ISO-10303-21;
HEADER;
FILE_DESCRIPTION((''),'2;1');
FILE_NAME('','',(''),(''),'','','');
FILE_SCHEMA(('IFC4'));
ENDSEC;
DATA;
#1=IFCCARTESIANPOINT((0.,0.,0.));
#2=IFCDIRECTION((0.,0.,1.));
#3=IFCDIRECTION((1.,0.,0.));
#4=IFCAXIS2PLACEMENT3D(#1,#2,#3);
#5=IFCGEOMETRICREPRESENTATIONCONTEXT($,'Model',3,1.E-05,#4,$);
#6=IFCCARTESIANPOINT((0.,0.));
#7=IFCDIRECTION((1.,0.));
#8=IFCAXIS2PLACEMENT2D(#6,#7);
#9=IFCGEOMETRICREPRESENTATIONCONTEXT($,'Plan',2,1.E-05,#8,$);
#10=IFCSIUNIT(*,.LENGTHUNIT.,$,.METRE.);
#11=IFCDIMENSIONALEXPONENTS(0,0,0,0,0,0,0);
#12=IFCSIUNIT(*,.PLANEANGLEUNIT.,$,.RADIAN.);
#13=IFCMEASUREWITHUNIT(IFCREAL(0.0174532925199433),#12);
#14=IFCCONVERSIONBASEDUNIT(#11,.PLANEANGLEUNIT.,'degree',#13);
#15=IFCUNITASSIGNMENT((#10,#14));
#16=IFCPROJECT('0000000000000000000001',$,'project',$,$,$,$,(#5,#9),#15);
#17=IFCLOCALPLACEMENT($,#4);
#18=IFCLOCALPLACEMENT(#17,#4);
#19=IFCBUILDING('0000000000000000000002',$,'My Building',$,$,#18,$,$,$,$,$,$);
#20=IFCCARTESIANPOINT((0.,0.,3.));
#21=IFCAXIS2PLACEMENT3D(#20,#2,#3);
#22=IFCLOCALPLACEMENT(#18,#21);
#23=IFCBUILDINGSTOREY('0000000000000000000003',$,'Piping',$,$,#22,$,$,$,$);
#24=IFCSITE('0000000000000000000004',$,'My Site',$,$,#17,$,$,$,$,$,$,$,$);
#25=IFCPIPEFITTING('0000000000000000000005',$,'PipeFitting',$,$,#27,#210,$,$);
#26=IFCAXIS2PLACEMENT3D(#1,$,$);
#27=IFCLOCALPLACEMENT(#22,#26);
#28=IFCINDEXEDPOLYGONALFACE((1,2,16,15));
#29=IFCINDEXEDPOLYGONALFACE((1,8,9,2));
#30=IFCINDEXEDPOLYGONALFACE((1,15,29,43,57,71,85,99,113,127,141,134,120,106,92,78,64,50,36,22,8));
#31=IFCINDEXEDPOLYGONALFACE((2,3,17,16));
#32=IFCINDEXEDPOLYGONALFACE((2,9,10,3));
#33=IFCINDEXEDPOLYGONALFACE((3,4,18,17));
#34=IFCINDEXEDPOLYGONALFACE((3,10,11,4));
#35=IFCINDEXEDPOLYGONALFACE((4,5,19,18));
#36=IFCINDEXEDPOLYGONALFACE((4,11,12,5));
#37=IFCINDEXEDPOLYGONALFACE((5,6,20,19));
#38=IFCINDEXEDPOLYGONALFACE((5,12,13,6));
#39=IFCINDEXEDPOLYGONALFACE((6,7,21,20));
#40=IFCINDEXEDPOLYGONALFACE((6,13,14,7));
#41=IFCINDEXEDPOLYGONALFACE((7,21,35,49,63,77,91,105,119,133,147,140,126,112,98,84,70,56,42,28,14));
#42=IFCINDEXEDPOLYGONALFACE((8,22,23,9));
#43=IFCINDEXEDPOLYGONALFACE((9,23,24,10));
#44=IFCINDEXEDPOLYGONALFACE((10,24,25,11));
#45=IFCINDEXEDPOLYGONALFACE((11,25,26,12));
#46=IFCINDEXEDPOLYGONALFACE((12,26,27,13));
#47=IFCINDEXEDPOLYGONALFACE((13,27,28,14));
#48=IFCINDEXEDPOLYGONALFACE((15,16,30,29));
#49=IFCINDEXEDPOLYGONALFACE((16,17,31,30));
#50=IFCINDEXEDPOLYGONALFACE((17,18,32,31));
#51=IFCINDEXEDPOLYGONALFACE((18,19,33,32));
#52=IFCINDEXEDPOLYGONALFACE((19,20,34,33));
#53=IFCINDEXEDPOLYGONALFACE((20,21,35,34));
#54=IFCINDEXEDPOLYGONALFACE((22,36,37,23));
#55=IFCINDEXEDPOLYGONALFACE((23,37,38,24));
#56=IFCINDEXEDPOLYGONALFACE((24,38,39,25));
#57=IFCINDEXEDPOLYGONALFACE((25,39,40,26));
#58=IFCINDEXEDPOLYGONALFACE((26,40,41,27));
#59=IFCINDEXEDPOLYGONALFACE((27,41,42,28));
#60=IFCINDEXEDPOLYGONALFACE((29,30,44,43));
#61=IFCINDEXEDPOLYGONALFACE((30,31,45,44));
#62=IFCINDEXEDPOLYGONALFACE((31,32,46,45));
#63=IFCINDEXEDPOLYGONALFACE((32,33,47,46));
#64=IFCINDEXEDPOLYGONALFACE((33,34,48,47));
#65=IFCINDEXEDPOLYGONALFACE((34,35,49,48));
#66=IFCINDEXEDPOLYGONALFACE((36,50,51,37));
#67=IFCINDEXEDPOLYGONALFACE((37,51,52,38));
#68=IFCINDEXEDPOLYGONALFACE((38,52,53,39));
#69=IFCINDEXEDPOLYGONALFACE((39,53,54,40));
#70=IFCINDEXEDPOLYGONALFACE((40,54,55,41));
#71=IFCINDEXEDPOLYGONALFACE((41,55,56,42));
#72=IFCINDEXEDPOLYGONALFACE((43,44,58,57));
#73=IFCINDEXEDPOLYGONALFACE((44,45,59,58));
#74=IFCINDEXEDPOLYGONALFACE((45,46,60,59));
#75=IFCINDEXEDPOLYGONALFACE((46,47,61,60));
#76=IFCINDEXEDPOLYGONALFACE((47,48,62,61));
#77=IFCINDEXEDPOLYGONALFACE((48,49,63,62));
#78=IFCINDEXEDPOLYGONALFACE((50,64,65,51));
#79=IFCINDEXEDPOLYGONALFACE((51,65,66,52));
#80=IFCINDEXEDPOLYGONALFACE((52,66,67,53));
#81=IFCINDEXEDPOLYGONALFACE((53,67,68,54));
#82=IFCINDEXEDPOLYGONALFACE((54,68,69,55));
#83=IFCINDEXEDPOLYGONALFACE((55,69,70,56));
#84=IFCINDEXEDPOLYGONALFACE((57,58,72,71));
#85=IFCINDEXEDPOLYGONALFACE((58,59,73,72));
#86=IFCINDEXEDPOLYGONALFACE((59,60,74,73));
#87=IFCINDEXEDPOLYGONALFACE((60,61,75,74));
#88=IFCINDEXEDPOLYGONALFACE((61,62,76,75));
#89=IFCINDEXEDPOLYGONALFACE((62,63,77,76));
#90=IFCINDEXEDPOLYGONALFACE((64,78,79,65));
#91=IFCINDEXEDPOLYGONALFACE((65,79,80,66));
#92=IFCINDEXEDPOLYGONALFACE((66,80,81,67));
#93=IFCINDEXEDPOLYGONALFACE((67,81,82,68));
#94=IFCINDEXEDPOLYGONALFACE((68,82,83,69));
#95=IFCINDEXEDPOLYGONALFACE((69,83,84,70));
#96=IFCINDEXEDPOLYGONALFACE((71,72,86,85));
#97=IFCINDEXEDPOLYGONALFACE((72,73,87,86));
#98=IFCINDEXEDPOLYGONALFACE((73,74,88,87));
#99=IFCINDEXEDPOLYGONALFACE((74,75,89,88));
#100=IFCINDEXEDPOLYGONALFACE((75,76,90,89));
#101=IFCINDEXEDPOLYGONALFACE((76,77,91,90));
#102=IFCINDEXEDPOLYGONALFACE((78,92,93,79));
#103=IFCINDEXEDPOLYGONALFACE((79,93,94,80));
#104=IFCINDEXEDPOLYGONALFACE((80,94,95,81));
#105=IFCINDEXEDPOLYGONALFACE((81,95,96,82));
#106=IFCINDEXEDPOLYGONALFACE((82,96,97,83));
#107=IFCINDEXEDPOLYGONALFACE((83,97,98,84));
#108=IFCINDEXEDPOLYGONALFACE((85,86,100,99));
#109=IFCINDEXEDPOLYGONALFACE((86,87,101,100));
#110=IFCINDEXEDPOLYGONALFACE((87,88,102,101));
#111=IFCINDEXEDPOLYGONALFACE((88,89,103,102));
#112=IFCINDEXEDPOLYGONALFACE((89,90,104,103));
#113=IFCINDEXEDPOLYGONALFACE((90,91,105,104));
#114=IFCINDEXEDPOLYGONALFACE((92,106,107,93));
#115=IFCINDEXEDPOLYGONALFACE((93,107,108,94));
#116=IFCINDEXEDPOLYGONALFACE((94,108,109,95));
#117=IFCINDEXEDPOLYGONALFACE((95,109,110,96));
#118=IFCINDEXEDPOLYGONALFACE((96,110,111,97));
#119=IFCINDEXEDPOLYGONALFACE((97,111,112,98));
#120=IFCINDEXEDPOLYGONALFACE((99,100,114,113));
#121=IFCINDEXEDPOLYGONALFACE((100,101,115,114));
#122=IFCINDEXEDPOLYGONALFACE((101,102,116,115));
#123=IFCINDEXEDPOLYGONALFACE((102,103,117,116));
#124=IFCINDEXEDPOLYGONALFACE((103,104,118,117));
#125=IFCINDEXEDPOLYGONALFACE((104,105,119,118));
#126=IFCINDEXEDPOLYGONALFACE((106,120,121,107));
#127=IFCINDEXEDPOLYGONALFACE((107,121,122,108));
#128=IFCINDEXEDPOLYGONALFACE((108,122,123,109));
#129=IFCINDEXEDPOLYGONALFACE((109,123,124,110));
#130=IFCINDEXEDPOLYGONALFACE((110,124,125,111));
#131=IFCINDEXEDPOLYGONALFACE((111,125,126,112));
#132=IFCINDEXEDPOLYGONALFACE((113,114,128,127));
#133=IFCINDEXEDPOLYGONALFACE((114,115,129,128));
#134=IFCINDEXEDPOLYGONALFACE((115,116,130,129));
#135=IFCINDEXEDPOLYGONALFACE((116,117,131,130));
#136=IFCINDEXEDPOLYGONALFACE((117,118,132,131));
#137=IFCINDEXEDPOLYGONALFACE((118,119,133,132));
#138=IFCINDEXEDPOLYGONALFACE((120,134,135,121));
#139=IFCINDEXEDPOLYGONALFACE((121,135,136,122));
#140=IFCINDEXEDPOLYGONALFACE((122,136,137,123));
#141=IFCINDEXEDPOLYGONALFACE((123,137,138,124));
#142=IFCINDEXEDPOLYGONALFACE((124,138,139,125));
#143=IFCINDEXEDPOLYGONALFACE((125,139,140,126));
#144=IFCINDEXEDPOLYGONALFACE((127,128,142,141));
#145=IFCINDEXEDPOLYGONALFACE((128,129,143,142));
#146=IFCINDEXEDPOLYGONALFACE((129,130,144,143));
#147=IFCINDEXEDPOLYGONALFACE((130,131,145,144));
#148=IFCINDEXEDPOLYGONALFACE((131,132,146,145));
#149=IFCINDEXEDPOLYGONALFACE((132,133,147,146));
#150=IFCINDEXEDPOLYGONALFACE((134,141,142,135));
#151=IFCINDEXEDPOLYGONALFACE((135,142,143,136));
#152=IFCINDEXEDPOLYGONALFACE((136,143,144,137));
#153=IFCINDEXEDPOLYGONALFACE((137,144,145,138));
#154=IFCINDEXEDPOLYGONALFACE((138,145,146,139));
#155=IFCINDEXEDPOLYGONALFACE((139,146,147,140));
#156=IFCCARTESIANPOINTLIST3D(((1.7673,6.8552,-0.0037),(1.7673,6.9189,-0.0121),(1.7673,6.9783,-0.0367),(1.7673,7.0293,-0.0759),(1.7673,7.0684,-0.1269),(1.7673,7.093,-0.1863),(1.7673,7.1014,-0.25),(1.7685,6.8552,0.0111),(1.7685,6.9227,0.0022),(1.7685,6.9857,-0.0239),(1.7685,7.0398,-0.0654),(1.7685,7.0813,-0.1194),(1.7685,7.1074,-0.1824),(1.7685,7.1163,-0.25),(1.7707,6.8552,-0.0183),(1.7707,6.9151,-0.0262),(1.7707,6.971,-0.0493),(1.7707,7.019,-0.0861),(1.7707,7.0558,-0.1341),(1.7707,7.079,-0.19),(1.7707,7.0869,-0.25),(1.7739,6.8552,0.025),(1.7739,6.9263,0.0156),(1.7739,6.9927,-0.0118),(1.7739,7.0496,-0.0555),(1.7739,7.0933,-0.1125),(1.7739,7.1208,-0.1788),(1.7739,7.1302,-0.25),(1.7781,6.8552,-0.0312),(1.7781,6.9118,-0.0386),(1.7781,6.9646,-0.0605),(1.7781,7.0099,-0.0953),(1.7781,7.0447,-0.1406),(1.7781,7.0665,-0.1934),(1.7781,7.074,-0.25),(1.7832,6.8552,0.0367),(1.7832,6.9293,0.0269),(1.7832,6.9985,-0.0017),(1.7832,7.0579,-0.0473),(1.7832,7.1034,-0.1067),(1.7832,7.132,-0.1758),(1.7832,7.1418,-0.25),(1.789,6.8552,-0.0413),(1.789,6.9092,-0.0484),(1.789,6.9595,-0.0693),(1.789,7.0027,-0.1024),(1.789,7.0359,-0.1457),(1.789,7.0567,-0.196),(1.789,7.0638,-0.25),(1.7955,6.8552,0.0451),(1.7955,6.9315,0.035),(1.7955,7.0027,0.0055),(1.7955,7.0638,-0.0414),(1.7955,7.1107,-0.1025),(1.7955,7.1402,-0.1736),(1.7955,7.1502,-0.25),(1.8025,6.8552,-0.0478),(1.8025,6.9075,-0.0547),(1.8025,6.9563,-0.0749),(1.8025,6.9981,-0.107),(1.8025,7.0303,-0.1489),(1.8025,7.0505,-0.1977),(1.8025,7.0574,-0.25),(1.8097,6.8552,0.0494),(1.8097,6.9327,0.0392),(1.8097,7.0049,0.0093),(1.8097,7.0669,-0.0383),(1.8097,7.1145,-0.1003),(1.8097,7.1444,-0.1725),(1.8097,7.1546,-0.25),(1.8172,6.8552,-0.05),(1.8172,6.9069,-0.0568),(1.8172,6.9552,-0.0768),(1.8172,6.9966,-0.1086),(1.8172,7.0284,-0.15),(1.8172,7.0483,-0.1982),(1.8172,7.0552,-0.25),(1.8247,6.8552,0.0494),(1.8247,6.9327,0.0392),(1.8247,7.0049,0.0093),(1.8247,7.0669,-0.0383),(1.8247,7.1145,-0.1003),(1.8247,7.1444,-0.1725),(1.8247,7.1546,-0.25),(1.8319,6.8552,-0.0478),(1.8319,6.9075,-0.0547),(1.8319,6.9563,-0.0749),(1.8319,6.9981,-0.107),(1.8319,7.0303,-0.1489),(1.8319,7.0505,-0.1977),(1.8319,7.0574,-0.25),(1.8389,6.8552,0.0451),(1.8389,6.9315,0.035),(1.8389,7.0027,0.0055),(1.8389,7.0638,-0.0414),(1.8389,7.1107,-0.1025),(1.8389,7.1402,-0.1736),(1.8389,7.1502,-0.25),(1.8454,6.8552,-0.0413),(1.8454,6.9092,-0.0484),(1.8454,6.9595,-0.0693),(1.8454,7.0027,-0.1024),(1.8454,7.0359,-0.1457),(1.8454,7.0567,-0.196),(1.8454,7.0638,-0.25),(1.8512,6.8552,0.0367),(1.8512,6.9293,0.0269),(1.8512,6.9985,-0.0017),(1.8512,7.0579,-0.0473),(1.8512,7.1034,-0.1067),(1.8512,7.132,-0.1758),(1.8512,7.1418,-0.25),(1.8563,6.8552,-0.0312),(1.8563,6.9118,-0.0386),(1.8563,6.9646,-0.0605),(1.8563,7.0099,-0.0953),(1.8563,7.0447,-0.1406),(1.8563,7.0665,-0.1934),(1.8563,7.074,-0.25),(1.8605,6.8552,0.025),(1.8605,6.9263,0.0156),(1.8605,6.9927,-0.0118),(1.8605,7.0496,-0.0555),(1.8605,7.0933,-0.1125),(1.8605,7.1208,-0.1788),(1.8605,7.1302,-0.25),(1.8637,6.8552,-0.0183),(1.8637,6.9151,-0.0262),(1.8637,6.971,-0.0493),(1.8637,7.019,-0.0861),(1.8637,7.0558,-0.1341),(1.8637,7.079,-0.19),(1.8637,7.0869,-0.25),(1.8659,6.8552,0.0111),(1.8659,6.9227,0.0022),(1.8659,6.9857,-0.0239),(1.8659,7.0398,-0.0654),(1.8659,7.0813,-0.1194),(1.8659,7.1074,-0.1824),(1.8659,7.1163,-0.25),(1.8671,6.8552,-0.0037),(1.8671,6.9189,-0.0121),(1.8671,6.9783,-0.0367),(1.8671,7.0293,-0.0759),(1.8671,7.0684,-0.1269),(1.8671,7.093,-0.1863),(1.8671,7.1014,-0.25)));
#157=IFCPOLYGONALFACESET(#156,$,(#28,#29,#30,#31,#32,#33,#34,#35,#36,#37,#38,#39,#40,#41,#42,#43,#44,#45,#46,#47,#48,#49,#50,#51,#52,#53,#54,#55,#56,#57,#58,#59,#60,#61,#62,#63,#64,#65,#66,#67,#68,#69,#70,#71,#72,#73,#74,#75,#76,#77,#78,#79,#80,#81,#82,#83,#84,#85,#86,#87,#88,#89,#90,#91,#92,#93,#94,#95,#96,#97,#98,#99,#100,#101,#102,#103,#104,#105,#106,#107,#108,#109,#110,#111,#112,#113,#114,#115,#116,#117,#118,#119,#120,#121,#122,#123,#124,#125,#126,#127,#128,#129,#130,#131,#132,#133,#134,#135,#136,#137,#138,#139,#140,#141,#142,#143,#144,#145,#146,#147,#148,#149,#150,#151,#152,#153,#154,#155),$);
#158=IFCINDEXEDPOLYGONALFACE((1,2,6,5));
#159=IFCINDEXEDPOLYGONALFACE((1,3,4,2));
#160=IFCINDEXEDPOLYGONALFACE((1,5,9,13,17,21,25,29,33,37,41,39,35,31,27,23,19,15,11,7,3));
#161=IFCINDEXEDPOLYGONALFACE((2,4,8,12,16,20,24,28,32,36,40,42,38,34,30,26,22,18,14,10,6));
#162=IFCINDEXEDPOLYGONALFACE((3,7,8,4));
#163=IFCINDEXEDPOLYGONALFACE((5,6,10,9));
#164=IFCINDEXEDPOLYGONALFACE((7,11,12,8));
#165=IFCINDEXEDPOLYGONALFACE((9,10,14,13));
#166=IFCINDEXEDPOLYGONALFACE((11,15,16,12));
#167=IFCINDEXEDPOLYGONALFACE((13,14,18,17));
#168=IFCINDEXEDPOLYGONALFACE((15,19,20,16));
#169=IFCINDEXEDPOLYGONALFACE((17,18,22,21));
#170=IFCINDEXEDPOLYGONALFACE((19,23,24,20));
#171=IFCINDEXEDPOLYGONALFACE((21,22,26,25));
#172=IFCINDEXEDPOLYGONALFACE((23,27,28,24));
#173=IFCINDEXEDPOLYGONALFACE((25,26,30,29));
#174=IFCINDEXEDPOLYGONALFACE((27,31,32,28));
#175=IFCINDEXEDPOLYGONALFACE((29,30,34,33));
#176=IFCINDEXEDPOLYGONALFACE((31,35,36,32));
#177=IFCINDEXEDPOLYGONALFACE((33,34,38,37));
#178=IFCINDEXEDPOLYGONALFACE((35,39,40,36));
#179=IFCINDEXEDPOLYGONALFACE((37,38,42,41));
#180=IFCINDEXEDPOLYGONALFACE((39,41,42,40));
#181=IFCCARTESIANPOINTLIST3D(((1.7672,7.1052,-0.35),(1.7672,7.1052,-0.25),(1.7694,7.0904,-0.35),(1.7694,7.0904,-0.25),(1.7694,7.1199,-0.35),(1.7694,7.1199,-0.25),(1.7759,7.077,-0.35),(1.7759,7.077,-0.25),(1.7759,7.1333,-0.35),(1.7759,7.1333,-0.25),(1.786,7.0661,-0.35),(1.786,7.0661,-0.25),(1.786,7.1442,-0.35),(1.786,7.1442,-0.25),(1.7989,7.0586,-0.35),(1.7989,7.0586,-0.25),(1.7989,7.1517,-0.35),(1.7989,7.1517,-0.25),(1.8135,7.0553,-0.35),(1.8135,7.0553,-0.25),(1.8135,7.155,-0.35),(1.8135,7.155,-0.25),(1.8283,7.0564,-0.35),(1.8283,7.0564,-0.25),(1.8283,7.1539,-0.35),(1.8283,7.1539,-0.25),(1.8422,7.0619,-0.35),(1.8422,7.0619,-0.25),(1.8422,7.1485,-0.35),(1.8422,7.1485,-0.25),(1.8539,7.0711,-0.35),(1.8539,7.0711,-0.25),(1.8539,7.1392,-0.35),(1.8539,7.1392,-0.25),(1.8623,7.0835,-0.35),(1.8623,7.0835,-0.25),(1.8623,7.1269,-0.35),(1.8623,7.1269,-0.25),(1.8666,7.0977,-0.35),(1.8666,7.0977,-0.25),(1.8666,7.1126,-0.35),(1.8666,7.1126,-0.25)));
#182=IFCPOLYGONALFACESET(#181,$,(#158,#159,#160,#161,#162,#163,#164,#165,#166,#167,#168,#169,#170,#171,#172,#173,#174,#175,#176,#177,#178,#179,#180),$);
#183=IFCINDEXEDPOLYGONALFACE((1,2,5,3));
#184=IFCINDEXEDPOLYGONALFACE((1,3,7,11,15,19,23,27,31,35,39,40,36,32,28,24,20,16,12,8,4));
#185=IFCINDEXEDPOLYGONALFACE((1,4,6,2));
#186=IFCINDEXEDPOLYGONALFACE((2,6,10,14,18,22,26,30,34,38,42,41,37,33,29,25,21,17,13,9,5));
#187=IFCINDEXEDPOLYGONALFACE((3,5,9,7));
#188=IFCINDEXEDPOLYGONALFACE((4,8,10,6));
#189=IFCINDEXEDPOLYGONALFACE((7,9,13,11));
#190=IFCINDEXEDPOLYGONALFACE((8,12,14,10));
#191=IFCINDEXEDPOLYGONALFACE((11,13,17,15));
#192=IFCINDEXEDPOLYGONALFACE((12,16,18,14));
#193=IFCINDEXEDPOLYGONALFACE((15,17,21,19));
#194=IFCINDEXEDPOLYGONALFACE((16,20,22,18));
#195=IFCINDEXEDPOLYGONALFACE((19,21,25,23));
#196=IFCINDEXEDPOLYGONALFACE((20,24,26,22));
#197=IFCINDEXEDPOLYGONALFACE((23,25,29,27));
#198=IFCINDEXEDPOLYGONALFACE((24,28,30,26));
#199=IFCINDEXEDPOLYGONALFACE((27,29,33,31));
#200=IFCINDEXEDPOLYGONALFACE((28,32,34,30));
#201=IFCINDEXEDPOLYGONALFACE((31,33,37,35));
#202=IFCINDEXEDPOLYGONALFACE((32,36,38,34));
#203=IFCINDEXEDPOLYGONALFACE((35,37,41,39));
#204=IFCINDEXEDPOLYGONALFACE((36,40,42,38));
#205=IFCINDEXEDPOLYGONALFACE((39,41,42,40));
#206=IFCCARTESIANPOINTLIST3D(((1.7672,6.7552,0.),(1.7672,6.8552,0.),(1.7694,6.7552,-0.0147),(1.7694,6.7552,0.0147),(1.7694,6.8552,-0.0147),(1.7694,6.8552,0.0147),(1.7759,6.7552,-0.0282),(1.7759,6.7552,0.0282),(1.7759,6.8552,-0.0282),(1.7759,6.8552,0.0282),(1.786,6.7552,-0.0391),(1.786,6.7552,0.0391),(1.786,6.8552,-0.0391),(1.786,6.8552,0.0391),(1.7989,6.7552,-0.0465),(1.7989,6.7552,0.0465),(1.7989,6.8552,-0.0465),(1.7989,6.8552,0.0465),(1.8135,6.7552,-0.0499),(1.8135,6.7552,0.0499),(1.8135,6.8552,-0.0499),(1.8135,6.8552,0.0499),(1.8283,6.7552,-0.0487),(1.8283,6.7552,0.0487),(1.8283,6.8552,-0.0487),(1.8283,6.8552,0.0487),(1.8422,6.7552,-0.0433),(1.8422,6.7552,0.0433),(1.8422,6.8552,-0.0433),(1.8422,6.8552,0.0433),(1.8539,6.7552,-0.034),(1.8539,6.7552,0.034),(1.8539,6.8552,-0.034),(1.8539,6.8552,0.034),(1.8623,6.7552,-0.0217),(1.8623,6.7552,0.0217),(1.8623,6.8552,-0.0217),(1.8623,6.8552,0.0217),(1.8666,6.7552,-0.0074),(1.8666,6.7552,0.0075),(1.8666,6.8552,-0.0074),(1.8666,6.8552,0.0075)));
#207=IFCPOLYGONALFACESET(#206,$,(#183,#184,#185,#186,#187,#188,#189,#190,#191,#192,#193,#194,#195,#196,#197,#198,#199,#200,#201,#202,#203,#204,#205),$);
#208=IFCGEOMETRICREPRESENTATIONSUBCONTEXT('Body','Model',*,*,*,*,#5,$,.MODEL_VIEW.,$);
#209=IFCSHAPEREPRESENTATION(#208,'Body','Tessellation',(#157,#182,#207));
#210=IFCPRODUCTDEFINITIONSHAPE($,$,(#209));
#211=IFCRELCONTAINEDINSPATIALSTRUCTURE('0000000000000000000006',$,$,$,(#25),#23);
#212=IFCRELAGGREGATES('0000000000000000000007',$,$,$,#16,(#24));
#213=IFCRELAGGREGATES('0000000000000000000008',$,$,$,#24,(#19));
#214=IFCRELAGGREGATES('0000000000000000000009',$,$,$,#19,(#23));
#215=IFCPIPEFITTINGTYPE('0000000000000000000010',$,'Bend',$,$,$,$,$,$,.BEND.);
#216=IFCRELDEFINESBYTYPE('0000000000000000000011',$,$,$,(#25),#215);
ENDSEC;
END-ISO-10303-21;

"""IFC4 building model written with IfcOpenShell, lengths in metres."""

from ifc_helpers import new_model, entity, si_unit, converted_unit, frame, origin_with_axes, origin_2d_with_axis, place, context, subcontext, project, spatial, line, indexed_curve, circle, outline, extrude, source, transform, mapped, type_object, type_shapes, element, save


model = new_model("IFC4")

# Units and contexts
model_context = context("Model", 3, precision=1e-05, world=origin_with_axes())
plan_context = context("Plan", 2, precision=1e-05, world=origin_2d_with_axis())
body_context = subcontext(model_context, "Body", "Model", "MODEL_VIEW")
ifc_project = project(units=[si_unit("LENGTHUNIT", "METRE"), converted_unit("PLANEANGLEUNIT", "degree", entity("IfcReal", 0.0174532925199433), si_unit("PLANEANGLEUNIT", "RADIAN"), dimensions=[0, 0, 0, 0, 0, 0, 0])], contexts=[model_context, plan_context])

# Site, building, storey
site_placement = place(None, origin_with_axes())
site = spatial("IfcSite", under=ifc_project, at=site_placement, Name="My Site")
building_placement = place(site_placement, origin_with_axes())
building = spatial("IfcBuilding", under=site, at=building_placement, Name="My Building")
storey_placement = place(building_placement, frame((0.0, 0.0, 3.0), z_axis=(0.0, 0.0, 1.0), x_axis=(1.0, 0.0, 0.0)))
storey = spatial("IfcBuildingStorey", under=building, at=storey_placement, Name="Piping")

# Pipe fitting, opening
pipe_fitting_type = type_object("IfcPipeFittingType", Name="Bend", PredefinedType="BEND")
shared_shape = source(origin_with_axes(), body_context, "Body", "SolidModel", [
    entity("IfcSweptDiskSolid", entity("IfcIndexedPolyCurve", entity("IfcCartesianPointList3D", [[0.0, 0.0, -0.1], [0.0, -0.0732, -0.2768], [0.0, -0.25, -0.35]]), [entity("IfcArcIndex", [1, 2, 3])]), 0.05),
    extrude(circle(Radius=0.05), origin_with_axes(), (0.0, 0.0, -1.0), 0.1),
    extrude(circle(Radius=0.05), frame((0.0, -0.25, -0.35), z_axis=(0.0, -1.0, 0.0), x_axis=(1.0, 0.0, 0.0)), (0.0, 0.0, 1.0), 0.1),
])
type_shapes(pipe_fitting_type, [shared_shape])
pipe_fitting_placement = place(storey_placement, frame((1.8172, 7.1052, -0.35), z_axis=(0.0, 0.0, -1.0), x_axis=(-1.0, 0.0, 0.0)))
pipe_fitting = element("IfcPipeFitting", 1, at=pipe_fitting_placement, inside=storey, type_object=pipe_fitting_type, Name="PipeFitting", context=body_context, shape_type="MappedRepresentation", body=[
    mapped(shared_shape, transform((0.0, 0.0, 0.0), x_axis=(1.0, 0.0, 0.0), y_axis=(0.0, 1.0, 0.0), z_axis=(0.0, 0.0, 1.0), scale=1.0)),
])
opening_placement = place(pipe_fitting_placement, frame((1.8172, -7.1052, 2.65), z_axis=(0.0, 0.0, -1.0), x_axis=(-1.0, 0.0, 0.0)))
element("IfcOpeningElement", 2, at=opening_placement, cuts=pipe_fitting, PredefinedType="OPENING", context=body_context, shape_type="SweptSolid", body=[
    extrude(outline(indexed_curve([(0.0, 0.0), (0.5, 0.0), (0.5, 0.5), (0.0, 0.5)], segments=[line(1, 2, 3, 4, 1)])), origin_with_axes(), (0.0, 0.0, 1.0), 0.5),
])

save(model, "model.ifc")
